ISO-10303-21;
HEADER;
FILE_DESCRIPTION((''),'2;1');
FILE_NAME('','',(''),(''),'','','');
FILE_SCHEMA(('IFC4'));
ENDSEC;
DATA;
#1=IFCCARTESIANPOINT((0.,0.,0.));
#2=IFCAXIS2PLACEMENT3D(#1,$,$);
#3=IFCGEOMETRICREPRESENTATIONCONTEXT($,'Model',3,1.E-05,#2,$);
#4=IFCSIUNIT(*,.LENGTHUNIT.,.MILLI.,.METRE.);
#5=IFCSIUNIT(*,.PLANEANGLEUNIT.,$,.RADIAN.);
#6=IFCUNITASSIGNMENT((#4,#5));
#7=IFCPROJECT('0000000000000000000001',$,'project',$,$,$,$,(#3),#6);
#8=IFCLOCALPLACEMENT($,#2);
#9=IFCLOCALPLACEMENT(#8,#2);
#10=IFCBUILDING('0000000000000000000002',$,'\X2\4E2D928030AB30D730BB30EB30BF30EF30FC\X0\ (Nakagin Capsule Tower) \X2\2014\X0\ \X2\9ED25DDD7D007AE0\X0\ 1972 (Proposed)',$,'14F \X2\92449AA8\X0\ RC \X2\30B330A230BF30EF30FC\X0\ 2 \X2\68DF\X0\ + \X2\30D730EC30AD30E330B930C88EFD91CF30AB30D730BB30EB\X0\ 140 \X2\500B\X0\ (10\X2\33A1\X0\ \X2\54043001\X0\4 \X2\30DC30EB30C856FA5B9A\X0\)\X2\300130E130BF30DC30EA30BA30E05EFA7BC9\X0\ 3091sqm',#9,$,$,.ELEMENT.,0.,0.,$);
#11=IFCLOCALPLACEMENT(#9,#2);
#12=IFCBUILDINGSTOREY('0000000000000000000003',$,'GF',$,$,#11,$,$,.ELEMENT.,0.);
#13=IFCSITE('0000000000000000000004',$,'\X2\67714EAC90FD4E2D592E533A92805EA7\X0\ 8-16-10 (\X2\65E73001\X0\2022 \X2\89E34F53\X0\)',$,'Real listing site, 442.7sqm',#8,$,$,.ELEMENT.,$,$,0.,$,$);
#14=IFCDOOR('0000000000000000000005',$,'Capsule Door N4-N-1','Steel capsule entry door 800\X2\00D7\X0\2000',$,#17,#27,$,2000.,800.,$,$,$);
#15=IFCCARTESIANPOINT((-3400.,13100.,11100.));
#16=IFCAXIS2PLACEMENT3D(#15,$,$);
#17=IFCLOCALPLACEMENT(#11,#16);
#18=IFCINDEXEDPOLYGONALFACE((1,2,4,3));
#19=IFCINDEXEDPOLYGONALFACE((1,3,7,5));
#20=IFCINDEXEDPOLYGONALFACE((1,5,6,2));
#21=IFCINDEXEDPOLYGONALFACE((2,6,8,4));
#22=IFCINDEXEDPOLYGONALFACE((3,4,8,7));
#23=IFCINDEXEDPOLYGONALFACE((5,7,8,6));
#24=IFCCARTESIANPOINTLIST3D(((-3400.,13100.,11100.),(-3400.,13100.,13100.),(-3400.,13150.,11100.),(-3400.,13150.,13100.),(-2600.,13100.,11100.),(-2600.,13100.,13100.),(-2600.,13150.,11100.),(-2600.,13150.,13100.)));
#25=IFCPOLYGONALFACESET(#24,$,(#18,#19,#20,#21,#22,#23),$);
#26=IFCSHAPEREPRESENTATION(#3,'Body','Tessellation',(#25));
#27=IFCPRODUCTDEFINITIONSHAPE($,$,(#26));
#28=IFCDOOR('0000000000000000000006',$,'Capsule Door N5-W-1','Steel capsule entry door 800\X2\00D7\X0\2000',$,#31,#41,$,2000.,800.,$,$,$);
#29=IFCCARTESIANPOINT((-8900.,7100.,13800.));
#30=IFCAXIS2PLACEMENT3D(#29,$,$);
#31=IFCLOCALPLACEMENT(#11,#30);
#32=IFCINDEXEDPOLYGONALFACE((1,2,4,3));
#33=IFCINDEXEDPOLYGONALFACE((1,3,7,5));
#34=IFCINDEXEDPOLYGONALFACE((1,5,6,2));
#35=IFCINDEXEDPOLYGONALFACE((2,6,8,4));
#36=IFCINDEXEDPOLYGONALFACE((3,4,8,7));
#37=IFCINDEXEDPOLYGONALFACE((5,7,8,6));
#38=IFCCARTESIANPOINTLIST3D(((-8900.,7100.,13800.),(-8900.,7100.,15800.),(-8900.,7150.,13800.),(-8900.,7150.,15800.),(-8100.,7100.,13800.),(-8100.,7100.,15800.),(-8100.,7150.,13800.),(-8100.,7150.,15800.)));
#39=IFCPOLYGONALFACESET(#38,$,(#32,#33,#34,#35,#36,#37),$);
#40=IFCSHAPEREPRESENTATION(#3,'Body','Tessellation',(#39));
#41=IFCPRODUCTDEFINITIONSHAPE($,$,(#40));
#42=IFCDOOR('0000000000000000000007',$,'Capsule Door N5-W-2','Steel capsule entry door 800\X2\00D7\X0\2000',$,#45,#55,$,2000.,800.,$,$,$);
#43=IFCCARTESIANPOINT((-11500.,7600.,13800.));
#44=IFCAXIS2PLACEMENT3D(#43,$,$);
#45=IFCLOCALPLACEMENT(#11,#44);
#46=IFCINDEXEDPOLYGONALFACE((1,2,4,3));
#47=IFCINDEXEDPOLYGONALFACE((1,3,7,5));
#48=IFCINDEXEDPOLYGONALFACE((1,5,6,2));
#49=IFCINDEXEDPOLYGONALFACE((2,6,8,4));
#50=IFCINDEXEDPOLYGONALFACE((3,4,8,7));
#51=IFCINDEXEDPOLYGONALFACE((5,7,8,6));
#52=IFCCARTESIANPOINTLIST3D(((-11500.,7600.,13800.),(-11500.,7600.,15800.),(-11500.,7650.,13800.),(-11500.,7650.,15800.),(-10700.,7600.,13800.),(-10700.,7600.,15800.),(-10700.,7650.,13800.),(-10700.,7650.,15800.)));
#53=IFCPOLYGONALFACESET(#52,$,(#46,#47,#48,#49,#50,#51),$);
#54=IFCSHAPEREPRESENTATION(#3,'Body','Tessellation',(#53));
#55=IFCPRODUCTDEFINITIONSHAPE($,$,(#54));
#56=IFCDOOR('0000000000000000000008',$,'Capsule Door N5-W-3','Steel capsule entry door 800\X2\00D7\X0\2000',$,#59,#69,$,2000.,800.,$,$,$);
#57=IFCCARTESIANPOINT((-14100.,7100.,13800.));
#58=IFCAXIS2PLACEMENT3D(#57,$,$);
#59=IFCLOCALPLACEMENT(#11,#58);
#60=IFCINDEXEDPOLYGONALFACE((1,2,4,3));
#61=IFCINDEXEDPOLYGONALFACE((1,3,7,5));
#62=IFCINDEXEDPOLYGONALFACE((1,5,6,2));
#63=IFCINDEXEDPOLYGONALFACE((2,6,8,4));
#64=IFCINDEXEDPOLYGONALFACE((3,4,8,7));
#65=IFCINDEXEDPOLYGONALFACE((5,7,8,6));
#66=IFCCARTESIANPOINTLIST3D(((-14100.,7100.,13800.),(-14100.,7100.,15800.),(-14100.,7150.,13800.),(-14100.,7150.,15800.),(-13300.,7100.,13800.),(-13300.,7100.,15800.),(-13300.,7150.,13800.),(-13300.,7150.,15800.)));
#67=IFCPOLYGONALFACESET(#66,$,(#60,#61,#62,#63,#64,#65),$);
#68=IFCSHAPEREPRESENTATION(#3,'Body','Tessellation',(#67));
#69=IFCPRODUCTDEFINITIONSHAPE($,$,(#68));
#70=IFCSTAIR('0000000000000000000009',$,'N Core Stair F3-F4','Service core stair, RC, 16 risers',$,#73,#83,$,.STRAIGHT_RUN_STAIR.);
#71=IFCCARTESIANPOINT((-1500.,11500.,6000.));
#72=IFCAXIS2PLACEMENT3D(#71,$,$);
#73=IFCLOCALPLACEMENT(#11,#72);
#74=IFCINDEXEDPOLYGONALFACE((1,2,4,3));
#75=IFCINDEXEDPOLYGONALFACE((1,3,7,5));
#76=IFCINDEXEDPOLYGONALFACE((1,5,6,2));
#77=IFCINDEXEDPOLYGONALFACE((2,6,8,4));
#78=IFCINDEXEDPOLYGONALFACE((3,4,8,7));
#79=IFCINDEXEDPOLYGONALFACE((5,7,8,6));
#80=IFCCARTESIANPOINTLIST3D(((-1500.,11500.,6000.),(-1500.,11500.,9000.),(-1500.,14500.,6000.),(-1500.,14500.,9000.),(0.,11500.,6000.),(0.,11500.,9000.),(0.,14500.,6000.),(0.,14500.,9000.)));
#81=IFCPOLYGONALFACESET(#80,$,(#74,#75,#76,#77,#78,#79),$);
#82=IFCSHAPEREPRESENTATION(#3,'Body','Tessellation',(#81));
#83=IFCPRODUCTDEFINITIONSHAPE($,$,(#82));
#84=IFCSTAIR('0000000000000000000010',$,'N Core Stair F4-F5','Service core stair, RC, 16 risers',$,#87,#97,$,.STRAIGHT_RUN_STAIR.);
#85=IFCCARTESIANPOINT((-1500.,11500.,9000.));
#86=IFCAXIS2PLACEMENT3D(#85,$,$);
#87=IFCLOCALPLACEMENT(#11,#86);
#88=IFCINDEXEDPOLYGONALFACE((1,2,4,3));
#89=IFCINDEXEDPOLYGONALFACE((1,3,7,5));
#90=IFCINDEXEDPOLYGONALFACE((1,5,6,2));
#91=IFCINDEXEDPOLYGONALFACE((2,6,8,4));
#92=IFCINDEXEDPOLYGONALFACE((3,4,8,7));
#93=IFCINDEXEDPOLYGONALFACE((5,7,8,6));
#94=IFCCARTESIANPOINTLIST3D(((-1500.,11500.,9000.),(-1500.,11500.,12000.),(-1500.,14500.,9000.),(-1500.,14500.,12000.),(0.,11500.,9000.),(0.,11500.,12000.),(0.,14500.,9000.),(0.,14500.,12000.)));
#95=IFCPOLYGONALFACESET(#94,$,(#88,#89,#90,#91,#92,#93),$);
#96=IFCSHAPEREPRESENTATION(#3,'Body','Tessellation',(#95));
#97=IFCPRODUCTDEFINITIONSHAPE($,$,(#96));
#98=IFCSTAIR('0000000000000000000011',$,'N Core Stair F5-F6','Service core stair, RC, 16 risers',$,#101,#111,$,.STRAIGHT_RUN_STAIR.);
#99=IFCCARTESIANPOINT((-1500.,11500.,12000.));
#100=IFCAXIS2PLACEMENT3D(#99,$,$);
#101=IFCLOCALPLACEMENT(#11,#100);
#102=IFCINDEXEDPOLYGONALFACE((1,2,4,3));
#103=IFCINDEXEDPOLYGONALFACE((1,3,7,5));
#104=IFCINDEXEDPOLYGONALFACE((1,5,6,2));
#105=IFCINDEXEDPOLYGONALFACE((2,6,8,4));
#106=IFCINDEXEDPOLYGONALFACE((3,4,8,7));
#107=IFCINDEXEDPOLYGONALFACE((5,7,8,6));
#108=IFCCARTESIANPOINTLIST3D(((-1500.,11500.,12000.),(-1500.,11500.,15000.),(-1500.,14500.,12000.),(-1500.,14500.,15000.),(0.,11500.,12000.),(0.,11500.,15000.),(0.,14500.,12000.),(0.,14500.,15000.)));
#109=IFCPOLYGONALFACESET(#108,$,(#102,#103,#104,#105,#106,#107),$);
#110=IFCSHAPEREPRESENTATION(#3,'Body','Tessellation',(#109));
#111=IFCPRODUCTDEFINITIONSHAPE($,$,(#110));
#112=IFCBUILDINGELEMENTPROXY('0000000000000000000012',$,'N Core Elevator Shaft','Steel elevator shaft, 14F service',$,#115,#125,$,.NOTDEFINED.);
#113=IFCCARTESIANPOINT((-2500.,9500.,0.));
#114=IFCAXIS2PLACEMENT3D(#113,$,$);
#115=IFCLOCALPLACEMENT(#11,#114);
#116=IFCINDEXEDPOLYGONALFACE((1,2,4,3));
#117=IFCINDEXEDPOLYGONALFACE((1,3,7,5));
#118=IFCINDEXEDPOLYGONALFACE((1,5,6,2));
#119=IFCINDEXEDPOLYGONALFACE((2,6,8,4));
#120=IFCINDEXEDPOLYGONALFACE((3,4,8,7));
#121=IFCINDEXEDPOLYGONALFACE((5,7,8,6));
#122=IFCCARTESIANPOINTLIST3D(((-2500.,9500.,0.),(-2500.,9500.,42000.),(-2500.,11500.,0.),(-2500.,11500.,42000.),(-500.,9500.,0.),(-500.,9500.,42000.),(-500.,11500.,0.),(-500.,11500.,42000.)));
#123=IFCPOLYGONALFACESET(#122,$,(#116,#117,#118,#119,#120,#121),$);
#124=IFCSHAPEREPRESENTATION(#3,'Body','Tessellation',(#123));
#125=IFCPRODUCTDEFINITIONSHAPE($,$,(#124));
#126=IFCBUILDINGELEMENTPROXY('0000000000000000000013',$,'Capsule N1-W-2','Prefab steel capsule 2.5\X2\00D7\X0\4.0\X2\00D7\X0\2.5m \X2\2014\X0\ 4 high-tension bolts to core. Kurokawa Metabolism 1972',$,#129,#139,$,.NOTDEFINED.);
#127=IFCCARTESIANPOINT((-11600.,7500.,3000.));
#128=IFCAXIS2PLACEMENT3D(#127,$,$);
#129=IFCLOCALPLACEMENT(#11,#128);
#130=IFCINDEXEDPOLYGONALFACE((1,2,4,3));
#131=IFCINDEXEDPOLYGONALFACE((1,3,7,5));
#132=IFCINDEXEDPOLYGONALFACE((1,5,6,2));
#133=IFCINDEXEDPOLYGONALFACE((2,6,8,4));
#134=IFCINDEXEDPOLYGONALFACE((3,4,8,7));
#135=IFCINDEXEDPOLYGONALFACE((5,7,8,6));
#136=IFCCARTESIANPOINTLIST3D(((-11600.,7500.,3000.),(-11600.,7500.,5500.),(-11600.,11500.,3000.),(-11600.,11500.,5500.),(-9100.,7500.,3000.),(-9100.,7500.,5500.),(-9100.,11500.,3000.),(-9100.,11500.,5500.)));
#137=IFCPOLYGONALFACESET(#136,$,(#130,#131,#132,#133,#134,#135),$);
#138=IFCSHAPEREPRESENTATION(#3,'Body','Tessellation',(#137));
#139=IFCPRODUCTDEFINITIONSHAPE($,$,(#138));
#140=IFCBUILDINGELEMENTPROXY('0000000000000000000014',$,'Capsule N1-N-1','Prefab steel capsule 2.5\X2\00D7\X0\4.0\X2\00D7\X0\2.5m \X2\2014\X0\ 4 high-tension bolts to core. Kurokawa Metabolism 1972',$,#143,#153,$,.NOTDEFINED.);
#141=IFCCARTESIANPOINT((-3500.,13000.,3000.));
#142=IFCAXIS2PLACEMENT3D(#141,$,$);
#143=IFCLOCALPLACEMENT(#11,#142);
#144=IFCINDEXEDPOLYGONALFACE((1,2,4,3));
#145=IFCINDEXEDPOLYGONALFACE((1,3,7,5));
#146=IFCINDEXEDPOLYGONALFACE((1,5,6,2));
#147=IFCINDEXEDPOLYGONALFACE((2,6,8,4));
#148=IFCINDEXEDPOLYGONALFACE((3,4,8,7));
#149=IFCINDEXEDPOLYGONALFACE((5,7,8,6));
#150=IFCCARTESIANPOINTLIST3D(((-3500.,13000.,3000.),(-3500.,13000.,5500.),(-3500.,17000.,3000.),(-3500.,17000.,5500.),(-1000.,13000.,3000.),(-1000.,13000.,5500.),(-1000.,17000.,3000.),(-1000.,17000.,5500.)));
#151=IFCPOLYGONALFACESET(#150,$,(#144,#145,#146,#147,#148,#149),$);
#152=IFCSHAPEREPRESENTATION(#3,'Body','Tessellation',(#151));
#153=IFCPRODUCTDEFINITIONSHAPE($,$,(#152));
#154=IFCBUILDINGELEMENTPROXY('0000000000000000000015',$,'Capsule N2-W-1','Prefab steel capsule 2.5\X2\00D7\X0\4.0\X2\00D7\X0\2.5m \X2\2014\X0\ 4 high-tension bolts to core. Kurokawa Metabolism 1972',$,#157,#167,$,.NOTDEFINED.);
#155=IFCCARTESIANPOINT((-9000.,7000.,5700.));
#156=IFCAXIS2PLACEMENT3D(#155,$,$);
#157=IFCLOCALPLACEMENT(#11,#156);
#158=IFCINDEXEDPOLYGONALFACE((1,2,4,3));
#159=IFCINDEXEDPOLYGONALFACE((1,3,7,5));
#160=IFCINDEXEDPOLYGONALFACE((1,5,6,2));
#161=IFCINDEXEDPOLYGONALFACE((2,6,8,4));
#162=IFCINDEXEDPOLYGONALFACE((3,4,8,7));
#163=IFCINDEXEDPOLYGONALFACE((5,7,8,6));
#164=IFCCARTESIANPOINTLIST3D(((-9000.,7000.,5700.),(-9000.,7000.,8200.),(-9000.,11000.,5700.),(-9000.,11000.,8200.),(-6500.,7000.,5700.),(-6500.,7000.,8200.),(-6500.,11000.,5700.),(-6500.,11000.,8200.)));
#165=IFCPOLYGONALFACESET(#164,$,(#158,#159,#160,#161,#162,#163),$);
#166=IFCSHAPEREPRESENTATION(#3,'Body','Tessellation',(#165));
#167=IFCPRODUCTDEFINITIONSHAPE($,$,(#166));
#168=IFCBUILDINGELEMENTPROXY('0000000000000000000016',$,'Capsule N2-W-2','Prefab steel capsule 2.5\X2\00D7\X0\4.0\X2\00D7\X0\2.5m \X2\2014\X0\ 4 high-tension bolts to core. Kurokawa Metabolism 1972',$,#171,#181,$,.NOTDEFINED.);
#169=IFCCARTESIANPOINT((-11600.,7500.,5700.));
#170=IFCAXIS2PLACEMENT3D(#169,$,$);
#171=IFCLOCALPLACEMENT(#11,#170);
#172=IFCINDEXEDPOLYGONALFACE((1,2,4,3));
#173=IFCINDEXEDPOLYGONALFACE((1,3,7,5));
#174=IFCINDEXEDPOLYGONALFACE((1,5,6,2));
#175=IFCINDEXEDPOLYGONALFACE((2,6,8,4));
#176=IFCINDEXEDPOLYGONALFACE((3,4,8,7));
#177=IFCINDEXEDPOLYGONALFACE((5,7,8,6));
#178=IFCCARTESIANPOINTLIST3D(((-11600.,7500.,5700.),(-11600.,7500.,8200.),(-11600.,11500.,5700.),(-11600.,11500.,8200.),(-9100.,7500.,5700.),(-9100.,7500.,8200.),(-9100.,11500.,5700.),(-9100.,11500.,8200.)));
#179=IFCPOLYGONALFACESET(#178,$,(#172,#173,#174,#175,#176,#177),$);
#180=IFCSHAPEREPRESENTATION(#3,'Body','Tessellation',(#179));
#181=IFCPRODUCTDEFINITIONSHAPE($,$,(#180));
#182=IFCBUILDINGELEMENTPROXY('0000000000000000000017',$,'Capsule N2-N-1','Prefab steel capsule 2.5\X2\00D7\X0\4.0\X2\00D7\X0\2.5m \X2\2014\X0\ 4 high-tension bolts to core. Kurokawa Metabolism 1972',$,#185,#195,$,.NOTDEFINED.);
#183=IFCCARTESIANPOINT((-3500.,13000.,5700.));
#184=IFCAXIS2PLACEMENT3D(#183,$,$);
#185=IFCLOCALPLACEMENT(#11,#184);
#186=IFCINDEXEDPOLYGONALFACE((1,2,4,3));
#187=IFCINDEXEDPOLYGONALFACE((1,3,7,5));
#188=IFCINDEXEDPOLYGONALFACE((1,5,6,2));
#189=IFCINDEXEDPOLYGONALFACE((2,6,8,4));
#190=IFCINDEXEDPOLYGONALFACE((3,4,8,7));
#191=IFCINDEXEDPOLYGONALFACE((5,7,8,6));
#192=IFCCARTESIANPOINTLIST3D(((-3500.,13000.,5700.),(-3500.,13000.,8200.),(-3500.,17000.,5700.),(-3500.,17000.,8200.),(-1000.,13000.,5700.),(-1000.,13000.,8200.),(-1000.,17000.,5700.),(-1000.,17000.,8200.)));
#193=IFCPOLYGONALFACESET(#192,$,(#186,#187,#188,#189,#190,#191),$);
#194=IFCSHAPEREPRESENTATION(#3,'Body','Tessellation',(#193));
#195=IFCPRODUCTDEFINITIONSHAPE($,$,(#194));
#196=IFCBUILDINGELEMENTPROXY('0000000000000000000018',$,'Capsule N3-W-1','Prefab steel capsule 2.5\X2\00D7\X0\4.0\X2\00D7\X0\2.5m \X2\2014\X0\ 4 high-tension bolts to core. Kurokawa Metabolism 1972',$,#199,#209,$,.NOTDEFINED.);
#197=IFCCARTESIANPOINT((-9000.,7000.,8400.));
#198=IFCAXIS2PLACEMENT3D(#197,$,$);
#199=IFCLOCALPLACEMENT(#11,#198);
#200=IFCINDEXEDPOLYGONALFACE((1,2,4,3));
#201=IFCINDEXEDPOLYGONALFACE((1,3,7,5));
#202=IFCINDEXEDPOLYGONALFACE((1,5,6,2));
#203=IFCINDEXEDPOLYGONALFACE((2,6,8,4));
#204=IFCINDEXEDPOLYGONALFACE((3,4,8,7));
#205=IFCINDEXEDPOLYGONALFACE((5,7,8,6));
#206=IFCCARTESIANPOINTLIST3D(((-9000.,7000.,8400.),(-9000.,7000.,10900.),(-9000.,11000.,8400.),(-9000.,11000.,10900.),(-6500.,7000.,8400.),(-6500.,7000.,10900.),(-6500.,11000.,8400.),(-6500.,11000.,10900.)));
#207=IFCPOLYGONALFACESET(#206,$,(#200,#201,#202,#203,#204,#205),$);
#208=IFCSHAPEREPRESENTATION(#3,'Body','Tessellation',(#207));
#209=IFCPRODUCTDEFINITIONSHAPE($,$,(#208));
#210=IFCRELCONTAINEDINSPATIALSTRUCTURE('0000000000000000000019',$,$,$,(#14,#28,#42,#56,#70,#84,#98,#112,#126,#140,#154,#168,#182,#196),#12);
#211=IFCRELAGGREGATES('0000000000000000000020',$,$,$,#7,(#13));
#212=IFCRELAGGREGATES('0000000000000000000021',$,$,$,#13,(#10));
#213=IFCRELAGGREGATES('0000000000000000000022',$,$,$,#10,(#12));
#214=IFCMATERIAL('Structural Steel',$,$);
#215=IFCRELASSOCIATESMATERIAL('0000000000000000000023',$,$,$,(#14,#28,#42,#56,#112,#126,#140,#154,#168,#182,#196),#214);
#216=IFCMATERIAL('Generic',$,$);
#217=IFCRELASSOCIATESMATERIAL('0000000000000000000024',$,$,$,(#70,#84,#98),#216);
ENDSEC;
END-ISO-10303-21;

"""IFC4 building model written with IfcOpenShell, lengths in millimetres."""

from ifc_helpers import new_model, si_unit, frame, frame_2d, origin, place, context, project, spatial, rectangle, extrude, material, element, save


model = new_model("IFC4")

# Units and contexts
model_context = context("Model", 3, precision=1e-05, world=origin())
ifc_project = project(units=[si_unit("LENGTHUNIT", "METRE", prefix="MILLI"), si_unit("PLANEANGLEUNIT", "RADIAN")], contexts=[model_context])

# Site, building, storey
site_placement = place(None, origin())
site = spatial("IfcSite", under=ifc_project, at=site_placement, Name="東京都中央区銀座 8-16-10 (旧、2022 解体)", ObjectType="Real listing site, 442.7sqm", CompositionType="ELEMENT", RefElevation=0.0)
building_placement = place(site_placement, origin())
building = spatial("IfcBuilding", under=site, at=building_placement, Name="中銀カプセルタワー (Nakagin Capsule Tower) — 黒川紀章 1972 (Proposed)", ObjectType="14F 鉄骨 RC コアタワー 2 棟 + プレキャスト軽量カプセル 140 個 (10㎡ 各、4 ボルト固定)、メタボリズム建築 3091sqm", CompositionType="ELEMENT", ElevationOfRefHeight=0.0, ElevationOfTerrain=0.0)
storey_placement = place(building_placement, origin())
storey = spatial("IfcBuildingStorey", under=building, at=storey_placement, Name="GF", CompositionType="ELEMENT", Elevation=0.0)

# Doors
ifc_material_1 = material(Name="Structural Steel")
door_1_placement = place(storey_placement, frame((-3400.0, 13100.0, 11100.0)))
element("IfcDoor", 1, at=door_1_placement, inside=storey, material=ifc_material_1, Name="Capsule Door N4-N-1", Description="Steel capsule entry door 800×2000", OverallHeight=2000.0, OverallWidth=800.0, context=model_context, shape_type="SweptSolid", body=[
    extrude(rectangle(XDim=800.0, YDim=50.0, at=frame_2d((400.0, 25.0))), frame((-3400.0, 13100.0, 11100.0)), (0.0, 0.0, 1.0), 2000.0),
])
door_2_placement = place(storey_placement, frame((-8900.0, 7100.0, 13800.0)))
element("IfcDoor", 2, at=door_2_placement, inside=storey, material=ifc_material_1, Name="Capsule Door N5-W-1", Description="Steel capsule entry door 800×2000", OverallHeight=2000.0, OverallWidth=800.0, context=model_context, shape_type="SweptSolid", body=[
    extrude(rectangle(XDim=800.0, YDim=50.0, at=frame_2d((400.0, 25.0))), frame((-8900.0, 7100.0, 13800.0)), (0.0, 0.0, 1.0), 2000.0),
])
door_3_placement = place(storey_placement, frame((-11500.0, 7600.0, 13800.0)))
element("IfcDoor", 3, at=door_3_placement, inside=storey, material=ifc_material_1, Name="Capsule Door N5-W-2", Description="Steel capsule entry door 800×2000", OverallHeight=2000.0, OverallWidth=800.0, context=model_context, shape_type="SweptSolid", body=[
    extrude(rectangle(XDim=800.0, YDim=50.0, at=frame_2d((400.0, 25.0))), frame((-11500.0, 7600.0, 13800.0)), (0.0, 0.0, 1.0), 2000.0),
])
door_4_placement = place(storey_placement, frame((-14100.0, 7100.0, 13800.0)))
element("IfcDoor", 4, at=door_4_placement, inside=storey, material=ifc_material_1, Name="Capsule Door N5-W-3", Description="Steel capsule entry door 800×2000", OverallHeight=2000.0, OverallWidth=800.0, context=model_context, shape_type="SweptSolid", body=[
    extrude(rectangle(XDim=800.0, YDim=50.0, at=frame_2d((400.0, 25.0))), frame((-14100.0, 7100.0, 13800.0)), (0.0, 0.0, 1.0), 2000.0),
])

# Stairs
ifc_material_2 = material(Name="Generic")
stair_1_placement = place(storey_placement, frame((-1500.0, 11500.0, 6000.0)))
element("IfcStair", 5, at=stair_1_placement, inside=storey, material=ifc_material_2, Name="N Core Stair F3-F4", Description="Service core stair, RC, 16 risers", PredefinedType="STRAIGHT_RUN_STAIR", context=model_context, shape_type="SweptSolid", body=[
    extrude(rectangle(XDim=1500.0, YDim=3000.0, at=frame_2d((750.0, 1500.0))), frame((-1500.0, 11500.0, 6000.0)), (0.0, 0.0, 1.0), 3000.0),
])
stair_2_placement = place(storey_placement, frame((-1500.0, 11500.0, 9000.0)))
element("IfcStair", 6, at=stair_2_placement, inside=storey, material=ifc_material_2, Name="N Core Stair F4-F5", Description="Service core stair, RC, 16 risers", PredefinedType="STRAIGHT_RUN_STAIR", context=model_context, shape_type="SweptSolid", body=[
    extrude(rectangle(XDim=1500.0, YDim=3000.0, at=frame_2d((750.0, 1500.0))), frame((-1500.0, 11500.0, 9000.0)), (0.0, 0.0, 1.0), 3000.0),
])
stair_3_placement = place(storey_placement, frame((-1500.0, 11500.0, 12000.0)))
element("IfcStair", 7, at=stair_3_placement, inside=storey, material=ifc_material_2, Name="N Core Stair F5-F6", Description="Service core stair, RC, 16 risers", PredefinedType="STRAIGHT_RUN_STAIR", context=model_context, shape_type="SweptSolid", body=[
    extrude(rectangle(XDim=1500.0, YDim=3000.0, at=frame_2d((750.0, 1500.0))), frame((-1500.0, 11500.0, 12000.0)), (0.0, 0.0, 1.0), 3000.0),
])

# Building element proxies
proxy_1_placement = place(storey_placement, frame((-2500.0, 9500.0, 0.0)))
element("IfcBuildingElementProxy", 8, at=proxy_1_placement, inside=storey, material=ifc_material_1, Name="N Core Elevator Shaft", Description="Steel elevator shaft, 14F service", PredefinedType="NOTDEFINED", context=model_context, shape_type="SweptSolid", body=[
    extrude(rectangle(XDim=2000.0, YDim=2000.0, at=frame_2d((1000.0, 1000.0))), frame((-2500.0, 9500.0, 0.0)), (0.0, 0.0, 1.0), 42000.0),
])
proxy_2_placement = place(storey_placement, frame((-11600.0, 7500.0, 3000.0)))
element("IfcBuildingElementProxy", 9, at=proxy_2_placement, inside=storey, material=ifc_material_1, Name="Capsule N1-W-2", Description="Prefab steel capsule 2.5×4.0×2.5m — 4 high-tension bolts to core. Kurokawa Metabolism 1972", PredefinedType="NOTDEFINED", context=model_context, shape_type="SweptSolid", body=[
    extrude(rectangle(XDim=2500.0, YDim=4000.0, at=frame_2d((1250.0, 2000.0))), frame((-11600.0, 7500.0, 3000.0)), (0.0, 0.0, 1.0), 2500.0),
])
proxy_3_placement = place(storey_placement, frame((-3500.0, 13000.0, 3000.0)))
element("IfcBuildingElementProxy", 10, at=proxy_3_placement, inside=storey, material=ifc_material_1, Name="Capsule N1-N-1", Description="Prefab steel capsule 2.5×4.0×2.5m — 4 high-tension bolts to core. Kurokawa Metabolism 1972", PredefinedType="NOTDEFINED", context=model_context, shape_type="SweptSolid", body=[
    extrude(rectangle(XDim=2500.0, YDim=4000.0, at=frame_2d((1250.0, 2000.0))), frame((-3500.0, 13000.0, 3000.0)), (0.0, 0.0, 1.0), 2500.0),
])
proxy_4_placement = place(storey_placement, frame((-9000.0, 7000.0, 5700.0)))
element("IfcBuildingElementProxy", 11, at=proxy_4_placement, inside=storey, material=ifc_material_1, Name="Capsule N2-W-1", Description="Prefab steel capsule 2.5×4.0×2.5m — 4 high-tension bolts to core. Kurokawa Metabolism 1972", PredefinedType="NOTDEFINED", context=model_context, shape_type="SweptSolid", body=[
    extrude(rectangle(XDim=2500.0, YDim=4000.0, at=frame_2d((1250.0, 2000.0))), frame((-9000.0, 7000.0, 5700.0)), (0.0, 0.0, 1.0), 2500.0),
])
proxy_5_placement = place(storey_placement, frame((-11600.0, 7500.0, 5700.0)))
element("IfcBuildingElementProxy", 12, at=proxy_5_placement, inside=storey, material=ifc_material_1, Name="Capsule N2-W-2", Description="Prefab steel capsule 2.5×4.0×2.5m — 4 high-tension bolts to core. Kurokawa Metabolism 1972", PredefinedType="NOTDEFINED", context=model_context, shape_type="SweptSolid", body=[
    extrude(rectangle(XDim=2500.0, YDim=4000.0, at=frame_2d((1250.0, 2000.0))), frame((-11600.0, 7500.0, 5700.0)), (0.0, 0.0, 1.0), 2500.0),
])
proxy_6_placement = place(storey_placement, frame((-3500.0, 13000.0, 5700.0)))
element("IfcBuildingElementProxy", 13, at=proxy_6_placement, inside=storey, material=ifc_material_1, Name="Capsule N2-N-1", Description="Prefab steel capsule 2.5×4.0×2.5m — 4 high-tension bolts to core. Kurokawa Metabolism 1972", PredefinedType="NOTDEFINED", context=model_context, shape_type="SweptSolid", body=[
    extrude(rectangle(XDim=2500.0, YDim=4000.0, at=frame_2d((1250.0, 2000.0))), frame((-3500.0, 13000.0, 5700.0)), (0.0, 0.0, 1.0), 2500.0),
])
proxy_7_placement = place(storey_placement, frame((-9000.0, 7000.0, 8400.0)))
element("IfcBuildingElementProxy", 14, at=proxy_7_placement, inside=storey, material=ifc_material_1, Name="Capsule N3-W-1", Description="Prefab steel capsule 2.5×4.0×2.5m — 4 high-tension bolts to core. Kurokawa Metabolism 1972", PredefinedType="NOTDEFINED", context=model_context, shape_type="SweptSolid", body=[
    extrude(rectangle(XDim=2500.0, YDim=4000.0, at=frame_2d((1250.0, 2000.0))), frame((-9000.0, 7000.0, 8400.0)), (0.0, 0.0, 1.0), 2500.0),
])

save(model, "model.ifc")
